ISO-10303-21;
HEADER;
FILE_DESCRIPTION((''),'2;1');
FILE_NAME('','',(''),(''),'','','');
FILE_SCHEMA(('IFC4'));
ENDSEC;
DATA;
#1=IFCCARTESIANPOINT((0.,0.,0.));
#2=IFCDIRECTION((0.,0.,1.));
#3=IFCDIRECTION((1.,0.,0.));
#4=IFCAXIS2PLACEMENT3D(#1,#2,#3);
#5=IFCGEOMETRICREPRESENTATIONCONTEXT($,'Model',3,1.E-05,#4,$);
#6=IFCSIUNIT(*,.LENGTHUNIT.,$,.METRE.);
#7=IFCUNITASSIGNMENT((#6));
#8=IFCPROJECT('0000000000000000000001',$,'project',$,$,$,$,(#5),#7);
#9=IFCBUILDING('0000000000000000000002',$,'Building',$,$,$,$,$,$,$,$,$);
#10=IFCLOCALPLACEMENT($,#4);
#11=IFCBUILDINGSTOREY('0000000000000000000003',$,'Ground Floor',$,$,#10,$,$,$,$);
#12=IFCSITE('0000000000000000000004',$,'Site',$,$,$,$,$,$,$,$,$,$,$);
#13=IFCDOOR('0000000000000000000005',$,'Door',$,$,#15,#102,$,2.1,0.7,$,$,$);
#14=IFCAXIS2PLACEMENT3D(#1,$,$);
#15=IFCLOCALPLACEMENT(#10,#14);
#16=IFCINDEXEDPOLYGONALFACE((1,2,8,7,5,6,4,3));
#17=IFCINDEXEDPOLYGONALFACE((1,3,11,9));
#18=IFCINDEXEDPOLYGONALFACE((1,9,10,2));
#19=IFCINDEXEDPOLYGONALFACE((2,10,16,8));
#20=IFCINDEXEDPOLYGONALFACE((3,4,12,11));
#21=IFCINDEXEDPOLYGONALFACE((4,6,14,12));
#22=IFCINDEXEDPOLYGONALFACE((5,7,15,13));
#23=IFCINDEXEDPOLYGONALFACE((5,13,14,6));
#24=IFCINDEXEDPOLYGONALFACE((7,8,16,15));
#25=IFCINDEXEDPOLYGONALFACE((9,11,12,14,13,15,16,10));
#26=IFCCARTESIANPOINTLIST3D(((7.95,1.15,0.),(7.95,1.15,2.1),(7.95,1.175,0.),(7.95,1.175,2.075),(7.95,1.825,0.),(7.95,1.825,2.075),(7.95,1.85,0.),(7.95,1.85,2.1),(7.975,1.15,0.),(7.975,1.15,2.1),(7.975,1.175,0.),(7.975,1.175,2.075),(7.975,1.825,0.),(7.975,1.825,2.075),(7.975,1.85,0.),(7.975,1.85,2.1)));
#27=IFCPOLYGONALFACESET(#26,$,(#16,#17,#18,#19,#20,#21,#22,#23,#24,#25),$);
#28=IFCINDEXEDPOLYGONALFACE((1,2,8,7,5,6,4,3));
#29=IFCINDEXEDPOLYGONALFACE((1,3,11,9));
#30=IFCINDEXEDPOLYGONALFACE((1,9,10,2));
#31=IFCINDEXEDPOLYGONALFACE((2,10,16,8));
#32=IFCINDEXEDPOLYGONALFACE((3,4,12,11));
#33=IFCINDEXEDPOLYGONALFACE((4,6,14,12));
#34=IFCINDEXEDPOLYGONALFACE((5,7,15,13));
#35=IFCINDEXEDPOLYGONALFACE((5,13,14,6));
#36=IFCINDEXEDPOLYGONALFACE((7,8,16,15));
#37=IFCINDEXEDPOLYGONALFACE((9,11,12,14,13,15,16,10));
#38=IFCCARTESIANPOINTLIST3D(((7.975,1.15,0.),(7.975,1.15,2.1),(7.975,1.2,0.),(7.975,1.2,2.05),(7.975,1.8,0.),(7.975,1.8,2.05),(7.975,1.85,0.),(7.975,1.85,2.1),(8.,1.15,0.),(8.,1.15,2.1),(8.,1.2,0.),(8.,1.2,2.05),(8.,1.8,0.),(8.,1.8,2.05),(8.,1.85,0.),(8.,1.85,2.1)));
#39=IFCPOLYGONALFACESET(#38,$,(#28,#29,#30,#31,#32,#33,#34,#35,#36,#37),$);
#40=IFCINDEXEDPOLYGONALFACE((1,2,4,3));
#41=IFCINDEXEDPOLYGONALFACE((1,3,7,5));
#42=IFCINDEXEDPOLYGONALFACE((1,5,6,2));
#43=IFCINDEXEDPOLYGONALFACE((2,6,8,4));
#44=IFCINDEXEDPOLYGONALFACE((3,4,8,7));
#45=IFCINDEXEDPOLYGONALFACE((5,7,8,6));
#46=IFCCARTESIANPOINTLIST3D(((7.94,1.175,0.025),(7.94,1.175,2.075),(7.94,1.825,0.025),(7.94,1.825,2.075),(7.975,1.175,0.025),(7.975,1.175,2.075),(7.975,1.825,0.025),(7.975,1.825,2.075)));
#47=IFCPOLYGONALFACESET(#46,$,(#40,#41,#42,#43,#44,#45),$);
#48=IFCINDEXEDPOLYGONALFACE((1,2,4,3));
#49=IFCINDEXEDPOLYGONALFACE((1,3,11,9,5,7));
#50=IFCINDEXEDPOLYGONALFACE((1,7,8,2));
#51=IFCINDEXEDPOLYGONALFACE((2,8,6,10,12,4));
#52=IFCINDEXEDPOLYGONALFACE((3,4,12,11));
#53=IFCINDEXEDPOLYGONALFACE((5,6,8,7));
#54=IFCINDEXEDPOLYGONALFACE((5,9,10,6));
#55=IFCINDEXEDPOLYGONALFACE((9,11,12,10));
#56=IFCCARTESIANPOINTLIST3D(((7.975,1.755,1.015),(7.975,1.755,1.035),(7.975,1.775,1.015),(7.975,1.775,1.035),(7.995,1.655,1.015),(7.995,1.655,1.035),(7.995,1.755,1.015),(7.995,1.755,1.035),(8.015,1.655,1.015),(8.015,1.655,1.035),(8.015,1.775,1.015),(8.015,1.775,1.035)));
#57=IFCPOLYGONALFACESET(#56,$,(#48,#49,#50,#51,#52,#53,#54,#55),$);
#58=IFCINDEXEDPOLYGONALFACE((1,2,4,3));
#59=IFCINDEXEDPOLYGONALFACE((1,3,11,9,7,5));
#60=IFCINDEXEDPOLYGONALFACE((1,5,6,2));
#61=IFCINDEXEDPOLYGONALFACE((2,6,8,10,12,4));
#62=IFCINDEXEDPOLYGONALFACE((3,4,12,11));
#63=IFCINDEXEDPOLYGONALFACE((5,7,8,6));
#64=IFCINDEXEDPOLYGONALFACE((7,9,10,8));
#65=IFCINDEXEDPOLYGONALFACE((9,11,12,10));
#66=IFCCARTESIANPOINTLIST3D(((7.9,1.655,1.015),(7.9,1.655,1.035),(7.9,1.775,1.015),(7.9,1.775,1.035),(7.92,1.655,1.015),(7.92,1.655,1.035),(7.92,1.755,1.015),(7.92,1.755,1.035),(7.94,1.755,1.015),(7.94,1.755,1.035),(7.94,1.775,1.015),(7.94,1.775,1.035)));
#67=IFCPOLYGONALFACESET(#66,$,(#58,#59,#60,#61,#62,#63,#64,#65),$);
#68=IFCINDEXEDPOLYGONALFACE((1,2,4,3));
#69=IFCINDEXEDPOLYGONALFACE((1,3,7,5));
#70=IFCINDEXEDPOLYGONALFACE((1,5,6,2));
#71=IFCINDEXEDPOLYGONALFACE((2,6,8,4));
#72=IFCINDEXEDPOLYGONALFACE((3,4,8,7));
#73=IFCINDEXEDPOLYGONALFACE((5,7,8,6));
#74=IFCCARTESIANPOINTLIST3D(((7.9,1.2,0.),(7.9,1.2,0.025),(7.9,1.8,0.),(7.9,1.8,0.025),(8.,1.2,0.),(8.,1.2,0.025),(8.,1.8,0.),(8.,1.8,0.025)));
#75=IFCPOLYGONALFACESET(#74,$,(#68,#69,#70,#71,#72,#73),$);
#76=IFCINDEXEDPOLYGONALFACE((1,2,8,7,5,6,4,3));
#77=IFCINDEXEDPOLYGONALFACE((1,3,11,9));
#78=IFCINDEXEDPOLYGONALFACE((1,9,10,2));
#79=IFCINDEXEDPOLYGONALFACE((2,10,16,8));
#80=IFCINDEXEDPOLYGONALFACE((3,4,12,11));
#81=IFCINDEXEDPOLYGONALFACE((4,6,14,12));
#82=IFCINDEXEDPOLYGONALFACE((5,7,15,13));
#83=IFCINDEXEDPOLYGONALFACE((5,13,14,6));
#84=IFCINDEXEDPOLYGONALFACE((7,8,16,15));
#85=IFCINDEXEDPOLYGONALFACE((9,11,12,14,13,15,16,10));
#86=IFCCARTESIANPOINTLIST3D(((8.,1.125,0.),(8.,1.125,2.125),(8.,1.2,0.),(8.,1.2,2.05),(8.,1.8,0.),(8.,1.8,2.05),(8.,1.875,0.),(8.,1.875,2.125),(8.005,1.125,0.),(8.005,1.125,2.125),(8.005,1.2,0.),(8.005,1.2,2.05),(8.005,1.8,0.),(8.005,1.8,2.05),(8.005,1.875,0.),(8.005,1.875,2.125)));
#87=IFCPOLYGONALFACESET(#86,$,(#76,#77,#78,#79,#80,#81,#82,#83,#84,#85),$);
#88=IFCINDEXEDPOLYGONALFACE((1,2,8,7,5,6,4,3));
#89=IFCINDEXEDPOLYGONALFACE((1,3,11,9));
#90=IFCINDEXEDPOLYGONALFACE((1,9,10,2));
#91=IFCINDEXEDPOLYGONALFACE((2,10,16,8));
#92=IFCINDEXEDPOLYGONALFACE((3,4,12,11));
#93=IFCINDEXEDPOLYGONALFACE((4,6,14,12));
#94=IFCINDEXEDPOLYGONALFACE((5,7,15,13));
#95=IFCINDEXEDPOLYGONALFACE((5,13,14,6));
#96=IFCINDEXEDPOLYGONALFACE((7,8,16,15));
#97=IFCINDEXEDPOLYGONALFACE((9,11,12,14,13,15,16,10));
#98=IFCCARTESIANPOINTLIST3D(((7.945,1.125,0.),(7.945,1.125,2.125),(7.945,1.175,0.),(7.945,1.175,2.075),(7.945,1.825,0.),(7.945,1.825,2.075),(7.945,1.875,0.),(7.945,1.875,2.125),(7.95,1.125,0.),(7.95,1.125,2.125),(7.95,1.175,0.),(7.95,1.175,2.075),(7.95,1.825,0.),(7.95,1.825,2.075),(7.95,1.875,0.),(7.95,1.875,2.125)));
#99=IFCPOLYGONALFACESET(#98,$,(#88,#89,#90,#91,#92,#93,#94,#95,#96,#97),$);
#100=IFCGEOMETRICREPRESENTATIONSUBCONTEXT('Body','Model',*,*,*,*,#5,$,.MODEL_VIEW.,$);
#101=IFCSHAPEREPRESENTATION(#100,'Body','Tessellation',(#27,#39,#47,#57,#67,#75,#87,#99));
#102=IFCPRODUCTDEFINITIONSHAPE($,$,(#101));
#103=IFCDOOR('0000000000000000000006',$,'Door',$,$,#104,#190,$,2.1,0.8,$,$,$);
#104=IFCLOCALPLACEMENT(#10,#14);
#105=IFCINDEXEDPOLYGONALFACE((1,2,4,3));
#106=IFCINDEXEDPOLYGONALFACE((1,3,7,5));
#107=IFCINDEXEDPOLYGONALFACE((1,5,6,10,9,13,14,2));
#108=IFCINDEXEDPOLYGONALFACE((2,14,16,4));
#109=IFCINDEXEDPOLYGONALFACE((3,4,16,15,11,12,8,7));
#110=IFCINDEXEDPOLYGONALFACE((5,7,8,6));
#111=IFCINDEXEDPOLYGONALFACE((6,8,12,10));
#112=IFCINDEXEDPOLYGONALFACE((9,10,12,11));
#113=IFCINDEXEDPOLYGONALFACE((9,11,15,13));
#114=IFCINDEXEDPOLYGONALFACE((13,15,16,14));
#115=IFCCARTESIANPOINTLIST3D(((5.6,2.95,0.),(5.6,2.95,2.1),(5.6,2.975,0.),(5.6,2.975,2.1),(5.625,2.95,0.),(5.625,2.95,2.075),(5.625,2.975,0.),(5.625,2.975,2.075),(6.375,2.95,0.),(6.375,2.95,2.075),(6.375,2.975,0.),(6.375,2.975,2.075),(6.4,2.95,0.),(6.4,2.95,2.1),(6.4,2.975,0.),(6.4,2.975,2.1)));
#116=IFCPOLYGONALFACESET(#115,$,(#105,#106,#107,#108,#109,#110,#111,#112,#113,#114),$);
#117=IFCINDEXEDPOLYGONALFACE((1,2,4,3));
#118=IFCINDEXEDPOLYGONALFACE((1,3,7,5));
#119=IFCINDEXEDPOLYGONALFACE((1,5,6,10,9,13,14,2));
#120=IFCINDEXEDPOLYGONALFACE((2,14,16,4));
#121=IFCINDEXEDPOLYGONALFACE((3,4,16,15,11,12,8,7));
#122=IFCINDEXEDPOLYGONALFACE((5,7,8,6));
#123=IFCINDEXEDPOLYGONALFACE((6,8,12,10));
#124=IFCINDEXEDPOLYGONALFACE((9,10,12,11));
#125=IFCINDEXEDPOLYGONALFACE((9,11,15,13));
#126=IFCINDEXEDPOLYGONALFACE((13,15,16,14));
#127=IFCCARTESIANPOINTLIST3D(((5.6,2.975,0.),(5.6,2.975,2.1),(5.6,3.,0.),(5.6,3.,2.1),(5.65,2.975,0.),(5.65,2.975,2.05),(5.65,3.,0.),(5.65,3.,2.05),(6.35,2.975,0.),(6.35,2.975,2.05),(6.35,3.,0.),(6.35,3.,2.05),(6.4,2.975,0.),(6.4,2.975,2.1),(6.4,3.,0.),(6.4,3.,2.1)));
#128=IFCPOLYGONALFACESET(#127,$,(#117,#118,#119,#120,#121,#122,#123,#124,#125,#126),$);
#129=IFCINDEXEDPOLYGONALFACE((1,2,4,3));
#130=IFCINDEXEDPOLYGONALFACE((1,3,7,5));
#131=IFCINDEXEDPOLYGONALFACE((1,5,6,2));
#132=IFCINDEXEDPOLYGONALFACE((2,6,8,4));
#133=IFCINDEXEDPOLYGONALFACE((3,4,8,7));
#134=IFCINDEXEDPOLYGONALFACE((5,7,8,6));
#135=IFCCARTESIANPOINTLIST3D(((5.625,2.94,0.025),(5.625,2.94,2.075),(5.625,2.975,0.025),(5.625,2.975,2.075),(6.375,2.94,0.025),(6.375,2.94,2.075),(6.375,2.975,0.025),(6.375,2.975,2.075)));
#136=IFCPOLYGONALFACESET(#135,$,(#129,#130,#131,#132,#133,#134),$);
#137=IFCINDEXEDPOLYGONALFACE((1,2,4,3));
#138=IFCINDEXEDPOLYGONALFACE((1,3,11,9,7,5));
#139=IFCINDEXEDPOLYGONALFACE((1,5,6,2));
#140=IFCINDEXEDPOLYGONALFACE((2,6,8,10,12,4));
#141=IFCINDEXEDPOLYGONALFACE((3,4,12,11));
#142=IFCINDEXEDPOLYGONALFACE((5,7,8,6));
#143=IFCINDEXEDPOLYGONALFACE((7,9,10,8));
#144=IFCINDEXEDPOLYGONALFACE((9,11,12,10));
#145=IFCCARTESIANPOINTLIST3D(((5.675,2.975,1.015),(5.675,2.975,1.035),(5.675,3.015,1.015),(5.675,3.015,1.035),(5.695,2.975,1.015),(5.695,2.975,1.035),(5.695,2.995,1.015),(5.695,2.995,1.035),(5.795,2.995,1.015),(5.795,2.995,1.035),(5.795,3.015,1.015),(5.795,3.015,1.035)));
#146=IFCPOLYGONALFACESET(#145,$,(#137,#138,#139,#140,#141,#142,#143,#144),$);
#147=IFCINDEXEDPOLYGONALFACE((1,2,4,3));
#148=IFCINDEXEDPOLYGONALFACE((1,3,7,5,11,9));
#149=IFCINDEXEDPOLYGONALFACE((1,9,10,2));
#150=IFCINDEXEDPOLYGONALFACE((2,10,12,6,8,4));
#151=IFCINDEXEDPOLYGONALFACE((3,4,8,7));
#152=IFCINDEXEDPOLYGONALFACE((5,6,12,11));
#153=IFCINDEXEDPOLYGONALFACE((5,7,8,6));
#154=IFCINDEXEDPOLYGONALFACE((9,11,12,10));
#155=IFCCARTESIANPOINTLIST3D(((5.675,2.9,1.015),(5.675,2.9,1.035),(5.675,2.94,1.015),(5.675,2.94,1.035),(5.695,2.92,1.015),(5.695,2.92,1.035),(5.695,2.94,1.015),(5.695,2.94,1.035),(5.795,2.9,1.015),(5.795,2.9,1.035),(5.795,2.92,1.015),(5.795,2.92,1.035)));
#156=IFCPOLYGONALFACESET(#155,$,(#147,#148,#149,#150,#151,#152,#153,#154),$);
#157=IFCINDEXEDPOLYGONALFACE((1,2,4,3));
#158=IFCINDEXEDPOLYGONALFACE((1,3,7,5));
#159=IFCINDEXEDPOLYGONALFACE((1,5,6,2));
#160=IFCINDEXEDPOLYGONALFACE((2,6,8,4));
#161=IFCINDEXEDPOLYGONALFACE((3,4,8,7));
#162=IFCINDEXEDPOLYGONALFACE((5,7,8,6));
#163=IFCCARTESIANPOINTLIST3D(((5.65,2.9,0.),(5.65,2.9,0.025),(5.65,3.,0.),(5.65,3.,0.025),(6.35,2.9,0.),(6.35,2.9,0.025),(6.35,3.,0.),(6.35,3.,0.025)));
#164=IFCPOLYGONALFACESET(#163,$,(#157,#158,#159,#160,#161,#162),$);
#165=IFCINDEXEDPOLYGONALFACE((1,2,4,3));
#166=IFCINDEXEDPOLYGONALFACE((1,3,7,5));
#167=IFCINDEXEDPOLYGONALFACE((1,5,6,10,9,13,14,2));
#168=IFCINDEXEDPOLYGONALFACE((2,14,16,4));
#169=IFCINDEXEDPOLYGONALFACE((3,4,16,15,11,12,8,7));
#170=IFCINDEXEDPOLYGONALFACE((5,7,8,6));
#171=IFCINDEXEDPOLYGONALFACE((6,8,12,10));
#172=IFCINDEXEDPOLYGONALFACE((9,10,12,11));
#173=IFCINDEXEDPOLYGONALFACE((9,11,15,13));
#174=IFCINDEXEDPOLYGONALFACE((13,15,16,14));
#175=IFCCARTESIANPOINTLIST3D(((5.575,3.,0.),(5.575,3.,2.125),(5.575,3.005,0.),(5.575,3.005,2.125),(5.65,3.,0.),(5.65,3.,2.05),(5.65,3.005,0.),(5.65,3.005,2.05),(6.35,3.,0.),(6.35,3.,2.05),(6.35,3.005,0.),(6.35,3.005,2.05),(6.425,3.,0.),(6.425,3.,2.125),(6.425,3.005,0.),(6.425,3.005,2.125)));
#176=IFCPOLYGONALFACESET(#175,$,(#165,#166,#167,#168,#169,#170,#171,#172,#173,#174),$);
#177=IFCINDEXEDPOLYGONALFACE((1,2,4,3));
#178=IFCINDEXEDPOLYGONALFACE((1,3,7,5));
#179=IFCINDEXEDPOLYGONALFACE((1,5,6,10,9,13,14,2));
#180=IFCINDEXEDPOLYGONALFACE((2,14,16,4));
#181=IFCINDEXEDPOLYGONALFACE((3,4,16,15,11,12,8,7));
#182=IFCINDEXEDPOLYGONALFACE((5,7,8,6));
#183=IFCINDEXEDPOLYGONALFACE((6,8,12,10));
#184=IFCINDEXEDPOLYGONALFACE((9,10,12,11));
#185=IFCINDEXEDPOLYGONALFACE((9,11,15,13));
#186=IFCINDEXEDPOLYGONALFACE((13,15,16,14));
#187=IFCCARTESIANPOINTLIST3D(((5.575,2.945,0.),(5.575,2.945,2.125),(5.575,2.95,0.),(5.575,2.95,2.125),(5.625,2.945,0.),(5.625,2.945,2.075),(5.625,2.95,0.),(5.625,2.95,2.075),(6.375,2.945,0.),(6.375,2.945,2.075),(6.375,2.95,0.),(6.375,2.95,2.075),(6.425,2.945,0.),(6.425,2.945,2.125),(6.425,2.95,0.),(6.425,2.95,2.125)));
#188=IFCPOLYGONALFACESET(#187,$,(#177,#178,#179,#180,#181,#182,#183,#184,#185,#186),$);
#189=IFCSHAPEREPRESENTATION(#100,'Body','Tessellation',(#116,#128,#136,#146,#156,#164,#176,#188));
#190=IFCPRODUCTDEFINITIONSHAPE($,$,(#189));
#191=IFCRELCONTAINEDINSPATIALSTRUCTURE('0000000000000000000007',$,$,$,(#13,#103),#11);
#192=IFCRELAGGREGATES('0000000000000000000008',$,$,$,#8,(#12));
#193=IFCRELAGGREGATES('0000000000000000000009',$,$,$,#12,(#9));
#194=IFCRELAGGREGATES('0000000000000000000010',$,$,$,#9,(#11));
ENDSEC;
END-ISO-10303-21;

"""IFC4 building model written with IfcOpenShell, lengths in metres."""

from ifc_helpers import new_model, si_unit, frame, origin_with_axes, place, context, subcontext, project, spatial, line, indexed_curve, outline, extrude, element, save


model = new_model("IFC4")

# Units and contexts
model_context = context("Model", 3, precision=1e-05, world=origin_with_axes())
body_context = subcontext(model_context, "Body", "Model", "MODEL_VIEW")
ifc_project = project(units=[si_unit("LENGTHUNIT", "METRE")], contexts=[model_context])

# Site, building, storey
site = spatial("IfcSite", under=ifc_project, Name="Site")
building = spatial("IfcBuilding", under=site, Name="Building")
storey_placement = place(None, origin_with_axes())
storey = spatial("IfcBuildingStorey", under=building, at=storey_placement, Name="Ground Floor")

# Doors
door_1_placement = place(storey_placement, frame((8.0, 1.15, 0.0), z_axis=(0.0, 0.0, 1.0), x_axis=(0.0, 1.0, 0.0)))
element("IfcDoor", 1, at=door_1_placement, inside=storey, Name="Door", OverallHeight=2.1, OverallWidth=0.7, context=body_context, shape_type="SweptSolid", body=[
    extrude(outline(indexed_curve([(0.0, 0.0), (0.0, 2.1), (0.7, 2.1), (0.7, 0.0), (0.675, 0.0), (0.675, 2.075), (0.025, 2.075), (0.025, 0.0)], segments=[line(1, 2, 3, 4, 5, 6, 7, 8, 1)])), frame((0.0, 0.025, 0.0), z_axis=(0.0, -1.0, 0.0), x_axis=(1.0, 0.0, 0.0)), (0.0, 0.0, -1.0), 0.025),
    extrude(outline(indexed_curve([(0.0, 0.0), (0.0, 2.1), (0.7, 2.1), (0.7, 0.0), (0.65, 0.0), (0.65, 2.05), (0.05, 2.05), (0.05, 0.0)], segments=[line(1, 2, 3, 4, 5, 6, 7, 8, 1)])), frame((0.0, 0.0, 0.0), z_axis=(0.0, -1.0, 0.0), x_axis=(1.0, 0.0, 0.0)), (0.0, 0.0, -1.0), 0.025),
    extrude(outline(indexed_curve([(0.0, 0.0), (0.65, 0.0), (0.65, 0.035), (0.0, 0.035)], segments=[line(1, 2, 3, 4, 1)])), frame((0.025, 0.025, 0.025), z_axis=(0.0, 0.0, 1.0), x_axis=(1.0, 0.0, 0.0)), (0.0, 0.0, 1.0), 2.05),
    extrude(outline(indexed_curve([(0.0, 0.0), (0.0, -0.04), (-0.12, -0.04), (-0.12, -0.02), (-0.02, -0.02), (-0.02, 0.0)], segments=[line(1, 2, 3, 4, 5, 6, 1)])), frame((0.625, 0.025, 1.015), z_axis=(0.0, 0.0, 1.0), x_axis=(1.0, 0.0, 0.0)), (0.0, 0.0, 1.0), 0.02),
    extrude(outline(indexed_curve([(0.0, 0.0), (0.0, 0.04), (-0.12, 0.04), (-0.12, 0.02), (-0.02, 0.02), (-0.02, 0.0)], segments=[line(1, 2, 3, 4, 5, 6, 1)])), frame((0.625, 0.06, 1.015), z_axis=(0.0, 0.0, 1.0), x_axis=(1.0, 0.0, 0.0)), (0.0, 0.0, 1.0), 0.02),
    extrude(outline(indexed_curve([(0.0, 0.0), (0.6, 0.0), (0.6, 0.1), (0.0, 0.1)], segments=[line(1, 2, 3, 4, 1)])), frame((0.05, 0.0, 0.0), z_axis=(0.0, 0.0, 1.0), x_axis=(1.0, 0.0, 0.0)), (0.0, 0.0, 1.0), 0.025),
    extrude(outline(indexed_curve([(0.0, 0.0), (0.0, 2.125), (0.75, 2.125), (0.75, 0.0), (0.675, 0.0), (0.675, 2.05), (0.075, 2.05), (0.075, 0.0)], segments=[line(1, 2, 3, 4, 5, 6, 7, 8, 1)])), frame((-0.025, -0.005, 0.0), z_axis=(0.0, -1.0, 0.0), x_axis=(1.0, 0.0, 0.0)), (0.0, 0.0, -1.0), 0.005),
    extrude(outline(indexed_curve([(0.0, 0.0), (0.0, 2.125), (0.75, 2.125), (0.75, 0.0), (0.7, 0.0), (0.7, 2.075), (0.05, 2.075), (0.05, 0.0)], segments=[line(1, 2, 3, 4, 5, 6, 7, 8, 1)])), frame((-0.025, 0.05, 0.0), z_axis=(0.0, -1.0, 0.0), x_axis=(1.0, 0.0, 0.0)), (0.0, 0.0, -1.0), 0.005),
])
door_2_placement = place(storey_placement, frame((6.4, 3.0, 0.0), z_axis=(0.0, 0.0, 1.0), x_axis=(-1.0, 0.0, 0.0)))
element("IfcDoor", 2, at=door_2_placement, inside=storey, Name="Door", OverallHeight=2.1, OverallWidth=0.8, context=body_context, shape_type="SweptSolid", body=[
    extrude(outline(indexed_curve([(0.0, 0.0), (0.0, 2.1), (0.8, 2.1), (0.8, 0.0), (0.775, 0.0), (0.775, 2.075), (0.025, 2.075), (0.025, 0.0)], segments=[line(1, 2, 3, 4, 5, 6, 7, 8, 1)])), frame((0.0, 0.025, 0.0), z_axis=(0.0, -1.0, 0.0), x_axis=(1.0, 0.0, 0.0)), (0.0, 0.0, -1.0), 0.025),
    extrude(outline(indexed_curve([(0.0, 0.0), (0.0, 2.1), (0.8, 2.1), (0.8, 0.0), (0.75, 0.0), (0.75, 2.05), (0.05, 2.05), (0.05, 0.0)], segments=[line(1, 2, 3, 4, 5, 6, 7, 8, 1)])), frame((0.0, 0.0, 0.0), z_axis=(0.0, -1.0, 0.0), x_axis=(1.0, 0.0, 0.0)), (0.0, 0.0, -1.0), 0.025),
    extrude(outline(indexed_curve([(0.0, 0.0), (0.75, 0.0), (0.75, 0.035), (0.0, 0.035)], segments=[line(1, 2, 3, 4, 1)])), frame((0.025, 0.025, 0.025), z_axis=(0.0, 0.0, 1.0), x_axis=(1.0, 0.0, 0.0)), (0.0, 0.0, 1.0), 2.05),
    extrude(outline(indexed_curve([(0.0, 0.0), (0.0, -0.04), (-0.12, -0.04), (-0.12, -0.02), (-0.02, -0.02), (-0.02, 0.0)], segments=[line(1, 2, 3, 4, 5, 6, 1)])), frame((0.725, 0.025, 1.015), z_axis=(0.0, 0.0, 1.0), x_axis=(1.0, 0.0, 0.0)), (0.0, 0.0, 1.0), 0.02),
    extrude(outline(indexed_curve([(0.0, 0.0), (0.0, 0.04), (-0.12, 0.04), (-0.12, 0.02), (-0.02, 0.02), (-0.02, 0.0)], segments=[line(1, 2, 3, 4, 5, 6, 1)])), frame((0.725, 0.06, 1.015), z_axis=(0.0, 0.0, 1.0), x_axis=(1.0, 0.0, 0.0)), (0.0, 0.0, 1.0), 0.02),
    extrude(outline(indexed_curve([(0.0, 0.0), (0.7, 0.0), (0.7, 0.1), (0.0, 0.1)], segments=[line(1, 2, 3, 4, 1)])), frame((0.05, 0.0, 0.0), z_axis=(0.0, 0.0, 1.0), x_axis=(1.0, 0.0, 0.0)), (0.0, 0.0, 1.0), 0.025),
    extrude(outline(indexed_curve([(0.0, 0.0), (0.0, 2.125), (0.85, 2.125), (0.85, 0.0), (0.775, 0.0), (0.775, 2.05), (0.075, 2.05), (0.075, 0.0)], segments=[line(1, 2, 3, 4, 5, 6, 7, 8, 1)])), frame((-0.025, -0.005, 0.0), z_axis=(0.0, -1.0, 0.0), x_axis=(1.0, 0.0, 0.0)), (0.0, 0.0, -1.0), 0.005),
    extrude(outline(indexed_curve([(0.0, 0.0), (0.0, 2.125), (0.85, 2.125), (0.85, 0.0), (0.8, 0.0), (0.8, 2.075), (0.05, 2.075), (0.05, 0.0)], segments=[line(1, 2, 3, 4, 5, 6, 7, 8, 1)])), frame((-0.025, 0.05, 0.0), z_axis=(0.0, -1.0, 0.0), x_axis=(1.0, 0.0, 0.0)), (0.0, 0.0, -1.0), 0.005),
])

save(model, "model.ifc")
